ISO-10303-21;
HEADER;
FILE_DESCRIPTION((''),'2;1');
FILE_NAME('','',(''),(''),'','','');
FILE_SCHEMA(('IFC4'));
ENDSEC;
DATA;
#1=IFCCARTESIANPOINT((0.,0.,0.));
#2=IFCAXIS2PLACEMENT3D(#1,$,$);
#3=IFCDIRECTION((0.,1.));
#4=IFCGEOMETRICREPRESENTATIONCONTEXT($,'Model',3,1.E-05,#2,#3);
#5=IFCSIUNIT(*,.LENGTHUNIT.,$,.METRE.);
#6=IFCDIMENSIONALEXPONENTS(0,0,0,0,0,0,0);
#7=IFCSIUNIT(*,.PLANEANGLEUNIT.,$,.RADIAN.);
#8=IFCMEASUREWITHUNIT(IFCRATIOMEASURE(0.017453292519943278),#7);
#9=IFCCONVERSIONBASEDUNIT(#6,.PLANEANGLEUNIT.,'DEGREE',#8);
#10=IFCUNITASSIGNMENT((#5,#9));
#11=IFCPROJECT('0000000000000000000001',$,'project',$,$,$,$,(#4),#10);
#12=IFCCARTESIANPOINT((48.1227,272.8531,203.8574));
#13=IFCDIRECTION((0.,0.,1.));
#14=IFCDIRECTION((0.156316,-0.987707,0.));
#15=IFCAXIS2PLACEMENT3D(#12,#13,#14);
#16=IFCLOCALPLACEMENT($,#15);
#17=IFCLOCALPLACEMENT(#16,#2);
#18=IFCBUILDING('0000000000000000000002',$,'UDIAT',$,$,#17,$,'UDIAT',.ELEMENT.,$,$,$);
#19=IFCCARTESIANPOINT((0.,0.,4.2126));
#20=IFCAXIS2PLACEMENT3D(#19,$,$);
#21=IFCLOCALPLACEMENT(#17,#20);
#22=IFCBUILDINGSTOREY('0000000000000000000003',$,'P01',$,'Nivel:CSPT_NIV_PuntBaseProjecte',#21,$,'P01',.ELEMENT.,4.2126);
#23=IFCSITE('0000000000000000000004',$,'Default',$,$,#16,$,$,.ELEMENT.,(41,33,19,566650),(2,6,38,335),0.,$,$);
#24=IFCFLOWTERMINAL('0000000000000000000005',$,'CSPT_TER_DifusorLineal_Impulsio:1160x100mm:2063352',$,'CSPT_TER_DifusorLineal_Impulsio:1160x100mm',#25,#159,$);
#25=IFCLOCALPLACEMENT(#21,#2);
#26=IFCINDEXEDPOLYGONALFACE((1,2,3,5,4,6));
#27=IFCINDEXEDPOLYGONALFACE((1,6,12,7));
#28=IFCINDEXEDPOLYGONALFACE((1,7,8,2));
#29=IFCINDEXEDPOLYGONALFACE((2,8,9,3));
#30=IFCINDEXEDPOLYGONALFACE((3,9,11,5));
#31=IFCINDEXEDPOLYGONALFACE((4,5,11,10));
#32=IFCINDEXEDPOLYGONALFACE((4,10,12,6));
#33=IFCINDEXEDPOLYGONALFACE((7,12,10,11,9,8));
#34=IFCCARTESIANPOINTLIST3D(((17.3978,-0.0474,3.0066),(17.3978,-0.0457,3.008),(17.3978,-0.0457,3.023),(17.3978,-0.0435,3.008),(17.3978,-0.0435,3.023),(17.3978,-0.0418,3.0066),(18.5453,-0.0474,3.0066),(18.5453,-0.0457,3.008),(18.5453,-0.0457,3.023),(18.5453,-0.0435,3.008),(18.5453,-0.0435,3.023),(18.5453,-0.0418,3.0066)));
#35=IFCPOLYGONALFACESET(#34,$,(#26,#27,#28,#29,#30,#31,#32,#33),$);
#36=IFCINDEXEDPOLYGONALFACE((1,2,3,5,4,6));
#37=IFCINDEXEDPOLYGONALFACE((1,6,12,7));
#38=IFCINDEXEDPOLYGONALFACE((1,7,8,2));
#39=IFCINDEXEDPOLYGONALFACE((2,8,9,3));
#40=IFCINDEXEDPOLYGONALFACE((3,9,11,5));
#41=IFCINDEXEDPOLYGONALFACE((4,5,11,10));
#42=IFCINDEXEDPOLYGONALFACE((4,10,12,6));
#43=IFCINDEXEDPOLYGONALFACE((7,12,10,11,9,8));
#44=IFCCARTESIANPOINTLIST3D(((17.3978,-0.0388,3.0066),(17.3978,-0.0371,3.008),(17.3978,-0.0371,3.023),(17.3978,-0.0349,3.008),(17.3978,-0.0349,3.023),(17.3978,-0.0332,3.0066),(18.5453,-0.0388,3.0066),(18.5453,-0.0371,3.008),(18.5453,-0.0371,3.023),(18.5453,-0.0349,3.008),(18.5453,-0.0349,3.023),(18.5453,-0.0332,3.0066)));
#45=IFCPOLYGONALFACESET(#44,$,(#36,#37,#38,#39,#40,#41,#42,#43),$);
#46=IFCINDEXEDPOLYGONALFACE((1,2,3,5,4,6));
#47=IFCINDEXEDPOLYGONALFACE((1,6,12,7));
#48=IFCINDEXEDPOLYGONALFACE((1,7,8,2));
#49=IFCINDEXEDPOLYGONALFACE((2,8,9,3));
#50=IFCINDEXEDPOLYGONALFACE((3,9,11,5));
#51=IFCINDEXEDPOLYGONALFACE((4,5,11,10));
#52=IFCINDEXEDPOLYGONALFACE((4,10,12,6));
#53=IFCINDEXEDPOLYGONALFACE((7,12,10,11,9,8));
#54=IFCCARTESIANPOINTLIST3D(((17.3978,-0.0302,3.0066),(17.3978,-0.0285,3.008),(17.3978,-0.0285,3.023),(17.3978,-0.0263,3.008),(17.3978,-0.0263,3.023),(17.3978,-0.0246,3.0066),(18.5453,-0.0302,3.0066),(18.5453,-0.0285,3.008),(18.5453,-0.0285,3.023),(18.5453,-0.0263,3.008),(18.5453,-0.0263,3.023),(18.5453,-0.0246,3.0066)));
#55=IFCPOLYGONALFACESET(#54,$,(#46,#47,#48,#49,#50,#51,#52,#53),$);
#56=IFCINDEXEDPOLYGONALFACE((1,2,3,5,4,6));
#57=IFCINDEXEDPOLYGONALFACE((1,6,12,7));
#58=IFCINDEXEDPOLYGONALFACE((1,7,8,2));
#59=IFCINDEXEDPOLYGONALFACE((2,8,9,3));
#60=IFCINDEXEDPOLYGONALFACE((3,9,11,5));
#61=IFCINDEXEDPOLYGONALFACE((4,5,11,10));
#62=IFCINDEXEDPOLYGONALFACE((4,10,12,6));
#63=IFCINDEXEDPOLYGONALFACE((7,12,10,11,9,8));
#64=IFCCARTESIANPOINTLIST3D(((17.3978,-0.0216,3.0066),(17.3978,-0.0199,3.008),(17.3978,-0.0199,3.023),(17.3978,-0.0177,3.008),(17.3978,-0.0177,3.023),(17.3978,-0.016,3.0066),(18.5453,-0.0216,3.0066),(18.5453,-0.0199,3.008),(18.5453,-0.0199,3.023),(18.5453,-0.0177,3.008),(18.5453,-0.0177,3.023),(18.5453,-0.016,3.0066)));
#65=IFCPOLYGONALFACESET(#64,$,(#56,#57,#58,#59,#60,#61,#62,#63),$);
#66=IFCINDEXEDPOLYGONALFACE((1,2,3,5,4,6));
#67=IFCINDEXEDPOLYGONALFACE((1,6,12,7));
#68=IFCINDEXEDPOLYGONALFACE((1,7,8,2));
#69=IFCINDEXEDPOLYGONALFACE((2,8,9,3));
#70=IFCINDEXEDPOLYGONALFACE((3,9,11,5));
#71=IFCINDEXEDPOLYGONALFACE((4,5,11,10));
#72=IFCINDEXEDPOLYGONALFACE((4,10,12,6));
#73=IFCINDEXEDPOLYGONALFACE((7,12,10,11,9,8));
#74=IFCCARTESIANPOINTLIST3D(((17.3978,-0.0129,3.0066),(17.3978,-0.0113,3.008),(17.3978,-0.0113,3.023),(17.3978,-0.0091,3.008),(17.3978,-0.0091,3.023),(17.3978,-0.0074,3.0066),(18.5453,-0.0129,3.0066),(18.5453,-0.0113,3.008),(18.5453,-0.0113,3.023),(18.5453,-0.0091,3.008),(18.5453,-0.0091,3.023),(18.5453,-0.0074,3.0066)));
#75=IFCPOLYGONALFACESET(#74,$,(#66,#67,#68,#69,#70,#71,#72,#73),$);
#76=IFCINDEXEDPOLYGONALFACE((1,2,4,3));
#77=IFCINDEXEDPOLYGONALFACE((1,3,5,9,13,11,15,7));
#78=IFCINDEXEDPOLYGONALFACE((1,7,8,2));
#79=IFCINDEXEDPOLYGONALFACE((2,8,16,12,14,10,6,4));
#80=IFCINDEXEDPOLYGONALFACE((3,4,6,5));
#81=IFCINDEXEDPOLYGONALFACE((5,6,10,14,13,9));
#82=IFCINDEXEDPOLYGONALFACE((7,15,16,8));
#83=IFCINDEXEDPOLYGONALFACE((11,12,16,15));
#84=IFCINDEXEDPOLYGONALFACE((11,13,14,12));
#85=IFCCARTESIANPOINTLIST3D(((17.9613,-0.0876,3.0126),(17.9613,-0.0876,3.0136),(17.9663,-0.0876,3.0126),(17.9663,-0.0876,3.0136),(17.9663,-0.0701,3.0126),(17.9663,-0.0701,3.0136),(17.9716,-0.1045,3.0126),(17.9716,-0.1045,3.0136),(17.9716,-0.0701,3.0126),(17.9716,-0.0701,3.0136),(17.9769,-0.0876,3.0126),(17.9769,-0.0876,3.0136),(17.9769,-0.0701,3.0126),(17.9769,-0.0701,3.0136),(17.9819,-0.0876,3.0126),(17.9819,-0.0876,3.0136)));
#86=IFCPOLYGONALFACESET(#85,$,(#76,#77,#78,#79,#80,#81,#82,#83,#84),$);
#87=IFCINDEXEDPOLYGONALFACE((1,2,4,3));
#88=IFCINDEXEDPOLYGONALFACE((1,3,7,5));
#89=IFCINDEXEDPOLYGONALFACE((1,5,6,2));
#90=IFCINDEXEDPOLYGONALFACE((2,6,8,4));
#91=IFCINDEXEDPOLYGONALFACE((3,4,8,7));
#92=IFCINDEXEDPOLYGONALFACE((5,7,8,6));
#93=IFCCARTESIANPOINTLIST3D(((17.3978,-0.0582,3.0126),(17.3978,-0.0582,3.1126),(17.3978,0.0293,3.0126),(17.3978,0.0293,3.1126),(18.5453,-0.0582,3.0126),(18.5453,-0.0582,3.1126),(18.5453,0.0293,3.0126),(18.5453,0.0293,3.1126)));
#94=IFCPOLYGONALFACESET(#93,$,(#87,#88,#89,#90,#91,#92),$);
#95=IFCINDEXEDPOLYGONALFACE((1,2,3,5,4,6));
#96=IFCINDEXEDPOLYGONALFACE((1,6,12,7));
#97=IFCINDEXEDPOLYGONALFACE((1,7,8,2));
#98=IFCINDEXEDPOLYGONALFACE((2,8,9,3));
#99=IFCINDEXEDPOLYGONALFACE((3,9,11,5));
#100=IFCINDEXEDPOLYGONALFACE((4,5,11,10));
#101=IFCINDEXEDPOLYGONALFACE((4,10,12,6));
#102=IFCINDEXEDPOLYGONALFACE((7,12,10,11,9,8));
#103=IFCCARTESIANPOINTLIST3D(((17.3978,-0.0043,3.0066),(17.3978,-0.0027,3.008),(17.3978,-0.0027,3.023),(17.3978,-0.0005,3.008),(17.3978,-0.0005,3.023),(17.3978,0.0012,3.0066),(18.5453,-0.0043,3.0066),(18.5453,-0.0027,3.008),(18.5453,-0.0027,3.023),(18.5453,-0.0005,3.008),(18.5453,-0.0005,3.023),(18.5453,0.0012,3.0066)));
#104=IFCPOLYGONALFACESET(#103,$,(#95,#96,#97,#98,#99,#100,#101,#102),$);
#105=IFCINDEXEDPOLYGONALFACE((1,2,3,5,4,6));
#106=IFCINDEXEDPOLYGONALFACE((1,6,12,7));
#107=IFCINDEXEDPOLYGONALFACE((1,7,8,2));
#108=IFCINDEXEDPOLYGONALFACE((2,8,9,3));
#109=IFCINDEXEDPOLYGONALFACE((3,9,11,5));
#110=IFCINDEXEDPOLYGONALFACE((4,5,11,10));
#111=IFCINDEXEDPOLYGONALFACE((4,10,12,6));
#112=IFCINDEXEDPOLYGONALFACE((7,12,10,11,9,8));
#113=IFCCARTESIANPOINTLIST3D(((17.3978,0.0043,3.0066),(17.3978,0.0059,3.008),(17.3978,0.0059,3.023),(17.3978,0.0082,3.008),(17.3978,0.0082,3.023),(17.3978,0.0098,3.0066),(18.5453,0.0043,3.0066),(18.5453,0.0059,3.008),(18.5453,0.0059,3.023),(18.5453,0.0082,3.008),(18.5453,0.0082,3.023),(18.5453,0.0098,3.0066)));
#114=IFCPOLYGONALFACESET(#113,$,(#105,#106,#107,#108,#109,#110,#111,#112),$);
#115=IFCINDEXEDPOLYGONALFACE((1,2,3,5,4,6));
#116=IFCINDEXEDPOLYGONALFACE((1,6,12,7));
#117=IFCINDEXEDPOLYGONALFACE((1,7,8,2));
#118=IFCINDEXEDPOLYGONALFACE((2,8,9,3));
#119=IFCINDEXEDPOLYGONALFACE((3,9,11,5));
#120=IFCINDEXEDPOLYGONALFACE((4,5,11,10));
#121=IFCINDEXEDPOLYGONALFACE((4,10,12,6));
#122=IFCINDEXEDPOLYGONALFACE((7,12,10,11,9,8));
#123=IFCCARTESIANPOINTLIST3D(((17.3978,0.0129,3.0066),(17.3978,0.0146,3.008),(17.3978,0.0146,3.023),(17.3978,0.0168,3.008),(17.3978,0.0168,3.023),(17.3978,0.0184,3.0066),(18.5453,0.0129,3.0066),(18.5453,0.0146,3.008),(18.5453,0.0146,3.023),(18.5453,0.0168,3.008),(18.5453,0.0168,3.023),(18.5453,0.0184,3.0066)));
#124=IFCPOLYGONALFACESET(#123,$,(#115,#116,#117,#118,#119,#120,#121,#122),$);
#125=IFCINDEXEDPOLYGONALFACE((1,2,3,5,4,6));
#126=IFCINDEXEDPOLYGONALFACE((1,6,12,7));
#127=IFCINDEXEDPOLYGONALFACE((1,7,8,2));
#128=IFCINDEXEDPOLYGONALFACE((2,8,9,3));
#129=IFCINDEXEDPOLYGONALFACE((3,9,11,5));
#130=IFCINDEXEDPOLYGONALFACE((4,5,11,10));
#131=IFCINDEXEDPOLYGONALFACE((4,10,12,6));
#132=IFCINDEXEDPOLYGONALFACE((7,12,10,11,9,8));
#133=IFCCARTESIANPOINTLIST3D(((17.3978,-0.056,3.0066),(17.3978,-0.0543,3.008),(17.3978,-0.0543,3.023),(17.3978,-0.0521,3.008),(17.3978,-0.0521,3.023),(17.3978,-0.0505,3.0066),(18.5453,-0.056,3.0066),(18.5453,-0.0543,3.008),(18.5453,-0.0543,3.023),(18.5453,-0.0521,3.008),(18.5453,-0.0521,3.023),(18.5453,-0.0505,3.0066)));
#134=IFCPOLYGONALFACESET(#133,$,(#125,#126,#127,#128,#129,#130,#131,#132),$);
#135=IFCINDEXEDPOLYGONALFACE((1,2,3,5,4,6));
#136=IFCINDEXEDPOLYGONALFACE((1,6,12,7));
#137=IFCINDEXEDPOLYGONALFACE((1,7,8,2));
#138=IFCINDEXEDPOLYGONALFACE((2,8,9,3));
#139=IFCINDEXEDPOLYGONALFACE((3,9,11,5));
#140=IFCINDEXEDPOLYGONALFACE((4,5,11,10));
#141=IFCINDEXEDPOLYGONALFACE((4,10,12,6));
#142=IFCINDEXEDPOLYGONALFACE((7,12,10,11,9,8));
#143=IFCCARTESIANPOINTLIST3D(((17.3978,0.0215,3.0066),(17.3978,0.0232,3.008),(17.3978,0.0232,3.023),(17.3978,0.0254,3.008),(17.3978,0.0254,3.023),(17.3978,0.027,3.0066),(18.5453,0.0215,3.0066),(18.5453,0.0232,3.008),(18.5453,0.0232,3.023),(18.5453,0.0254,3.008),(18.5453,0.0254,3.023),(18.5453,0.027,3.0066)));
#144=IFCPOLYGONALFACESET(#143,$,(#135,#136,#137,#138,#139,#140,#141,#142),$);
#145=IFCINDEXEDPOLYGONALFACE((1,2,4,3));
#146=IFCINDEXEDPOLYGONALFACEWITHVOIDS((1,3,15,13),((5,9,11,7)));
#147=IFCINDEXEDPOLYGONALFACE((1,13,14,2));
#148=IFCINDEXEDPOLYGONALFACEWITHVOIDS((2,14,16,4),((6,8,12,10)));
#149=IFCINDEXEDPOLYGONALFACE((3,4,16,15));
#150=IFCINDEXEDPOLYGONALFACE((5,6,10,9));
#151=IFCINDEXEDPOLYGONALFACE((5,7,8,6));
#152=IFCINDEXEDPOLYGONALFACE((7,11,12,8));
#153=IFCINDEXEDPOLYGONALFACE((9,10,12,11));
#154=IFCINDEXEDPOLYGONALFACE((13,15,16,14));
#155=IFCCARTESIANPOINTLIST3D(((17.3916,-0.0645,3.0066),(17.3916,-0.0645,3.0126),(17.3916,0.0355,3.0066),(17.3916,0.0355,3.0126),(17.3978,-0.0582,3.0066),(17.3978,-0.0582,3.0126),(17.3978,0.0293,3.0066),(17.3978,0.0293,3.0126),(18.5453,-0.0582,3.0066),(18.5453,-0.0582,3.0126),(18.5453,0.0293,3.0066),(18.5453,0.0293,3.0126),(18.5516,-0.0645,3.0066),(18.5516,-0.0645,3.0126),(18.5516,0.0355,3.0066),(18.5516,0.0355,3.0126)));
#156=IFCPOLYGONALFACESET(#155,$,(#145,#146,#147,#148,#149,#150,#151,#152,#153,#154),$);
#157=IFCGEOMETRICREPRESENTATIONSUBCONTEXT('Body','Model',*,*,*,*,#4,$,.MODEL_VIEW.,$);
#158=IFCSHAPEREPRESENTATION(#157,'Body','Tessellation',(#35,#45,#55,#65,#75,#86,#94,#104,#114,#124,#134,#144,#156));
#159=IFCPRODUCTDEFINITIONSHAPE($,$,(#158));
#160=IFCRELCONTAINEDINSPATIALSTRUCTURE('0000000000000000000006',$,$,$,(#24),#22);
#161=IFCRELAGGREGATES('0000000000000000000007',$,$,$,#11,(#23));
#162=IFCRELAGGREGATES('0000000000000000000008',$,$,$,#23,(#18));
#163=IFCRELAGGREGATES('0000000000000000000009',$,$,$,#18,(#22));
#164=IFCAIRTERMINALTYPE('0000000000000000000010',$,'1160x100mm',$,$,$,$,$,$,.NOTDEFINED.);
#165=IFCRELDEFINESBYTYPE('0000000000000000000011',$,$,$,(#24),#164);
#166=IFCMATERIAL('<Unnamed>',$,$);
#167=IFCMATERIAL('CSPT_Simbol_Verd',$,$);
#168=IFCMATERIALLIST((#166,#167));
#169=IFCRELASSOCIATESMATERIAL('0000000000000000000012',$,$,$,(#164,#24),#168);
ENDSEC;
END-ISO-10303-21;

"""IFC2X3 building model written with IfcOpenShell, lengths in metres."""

from ifc_helpers import new_model, entity, si_unit, converted_unit, direction, frame, origin, origin_2d_with_axis, place, context, subcontext, project, spatial, polyline, rectangle, outline, extrude, source, transform, mapped, material, material_list, type_object, type_shapes, element, save


model = new_model("IFC2X3")

# Units and contexts
model_context = context("Model", 3, precision=1e-05, world=origin(), true_north=direction((0.0, 1.0)))
body_context = subcontext(model_context, "Body", "Model", "MODEL_VIEW")
ifc_project = project(units=[si_unit("LENGTHUNIT", "METRE"), converted_unit("PLANEANGLEUNIT", "DEGREE", entity("IfcRatioMeasure", 0.017453292519943278), si_unit("PLANEANGLEUNIT", "RADIAN"), dimensions=[0, 0, 0, 0, 0, 0, 0])], contexts=[model_context])

# Site, building, storey
site_placement = place(None, frame((48.1227, 272.8531, 203.8574), z_axis=(0.0, 0.0, 1.0), x_axis=(0.156316, -0.987707, 0.0)))
site = spatial("IfcSite", under=ifc_project, at=site_placement, Name="Default", CompositionType="ELEMENT", RefLatitude=(41, 33, 19, 566650), RefLongitude=(2, 6, 38, 335), RefElevation=0.0)
building_placement = place(site_placement, origin())
building = spatial("IfcBuilding", under=site, at=building_placement, Name="UDIAT", LongName="UDIAT", CompositionType="ELEMENT")
storey_placement = place(building_placement, frame((0.0, 0.0, 4.2126)))
storey = spatial("IfcBuildingStorey", under=building, at=storey_placement, Name="P01", ObjectType="Nivel:CSPT_NIV_PuntBaseProjecte", LongName="P01", CompositionType="ELEMENT", Elevation=4.2126)

# Shared definitions
ifc_material_1 = material(Name="<Unnamed>")

# Flow terminal
ifc_material_2 = material(Name="CSPT_Simbol_Verd")
ifc_material_list = material_list([ifc_material_1, ifc_material_2])
air_terminal_type = type_object("IfcAirTerminalType", Name="1160x100mm", PredefinedType="NOTDEFINED", material=ifc_material_list)
shared_shape_1 = source(origin(), body_context, "Body", "SweptSolid", [
    extrude(outline(polyline([(0.0037, 0.0028), (0.0059, 0.0028), (0.0016, 0.0063), (0.002, 0.0042), (-0.0074, -0.0074), (-0.0057, -0.0088), (0.0037, 0.0028)])), frame((-0.5737, 0.0301, -0.0001), z_axis=(1.0, 0.0, 0.0), x_axis=(0.0, -0.776119, -0.630587)), (0.0, 0.0, 1.0), 1.1475),
    extrude(outline(polyline([(0.0037, 0.0028), (0.0059, 0.0028), (0.0016, 0.0063), (0.002, 0.0042), (-0.0074, -0.0074), (-0.0057, -0.0088), (0.0037, 0.0028)])), frame((-0.5737, 0.0215, -0.0001), z_axis=(1.0, 0.0, 0.0), x_axis=(0.0, -0.776119, -0.630587)), (0.0, 0.0, 1.0), 1.1475),
    extrude(outline(polyline([(0.0037, 0.0028), (0.0059, 0.0028), (0.0016, 0.0063), (0.002, 0.0042), (-0.0074, -0.0074), (-0.0057, -0.0088), (0.0037, 0.0028)])), frame((-0.5737, 0.0129, -0.0001), z_axis=(1.0, 0.0, 0.0), x_axis=(0.0, -0.776119, -0.630587)), (0.0, 0.0, 1.0), 1.1475),
    extrude(outline(polyline([(0.0037, 0.0028), (0.0059, 0.0028), (0.0016, 0.0063), (0.002, 0.0042), (-0.0074, -0.0074), (-0.0057, -0.0088), (0.0037, 0.0028)])), frame((-0.5737, 0.0043, -0.0001), z_axis=(1.0, 0.0, 0.0), x_axis=(0.0, -0.776119, -0.630587)), (0.0, 0.0, 1.0), 1.1475),
    extrude(outline(polyline([(0.0037, 0.0028), (0.0059, 0.0028), (0.0016, 0.0063), (0.002, 0.0042), (-0.0074, -0.0074), (-0.0057, -0.0088), (0.0037, 0.0028)])), frame((-0.5737, -0.0043, -0.0001), z_axis=(1.0, 0.0, 0.0), x_axis=(0.0, -0.776119, -0.630587)), (0.0, 0.0, 1.0), 1.1475),
    extrude(outline(polyline([(0.0, -0.013), (0.0053, -0.013), (0.0053, 0.0045), (0.0103, 0.0045), (0.0, 0.0213), (-0.0103, 0.0045), (-0.0053, 0.0045), (-0.0053, -0.013), (0.0, -0.013)])), frame((0.0, 0.0687, 0.0)), (0.0, 0.0, 1.0), 0.001),
    extrude(rectangle(XDim=1.1475, YDim=0.0875, at=origin_2d_with_axis()), frame((0.0, 0.0, 0.0), z_axis=(0.0, 0.0, 1.0), x_axis=(-1.0, 0.0, 0.0)), (0.0, 0.0, 1.0), 0.1),
    extrude(outline(polyline([(0.0037, 0.0028), (0.0059, 0.0028), (0.0016, 0.0063), (0.002, 0.0042), (-0.0074, -0.0074), (-0.0057, -0.0088), (0.0037, 0.0028)])), frame((-0.5737, -0.0129, -0.0001), z_axis=(1.0, 0.0, 0.0), x_axis=(0.0, -0.776119, -0.630587)), (0.0, 0.0, 1.0), 1.1475),
    extrude(outline(polyline([(0.0037, 0.0028), (0.0059, 0.0028), (0.0016, 0.0063), (0.002, 0.0042), (-0.0074, -0.0074), (-0.0057, -0.0088), (0.0037, 0.0028)])), frame((-0.5737, -0.0215, -0.0001), z_axis=(1.0, 0.0, 0.0), x_axis=(0.0, -0.776119, -0.630587)), (0.0, 0.0, 1.0), 1.1475),
    extrude(outline(polyline([(0.0037, 0.0028), (0.0059, 0.0028), (0.0016, 0.0063), (0.002, 0.0042), (-0.0074, -0.0074), (-0.0057, -0.0088), (0.0037, 0.0028)])), frame((-0.5737, -0.0301, -0.0001), z_axis=(1.0, 0.0, 0.0), x_axis=(0.0, -0.776119, -0.630587)), (0.0, 0.0, 1.0), 1.1475),
    extrude(outline(polyline([(0.0037, 0.0028), (0.0059, 0.0028), (0.0016, 0.0063), (0.002, 0.0042), (-0.0074, -0.0074), (-0.0057, -0.0088), (0.0037, 0.0028)])), frame((-0.5737, 0.0388, -0.0001), z_axis=(1.0, 0.0, 0.0), x_axis=(0.0, -0.776119, -0.630587)), (0.0, 0.0, 1.0), 1.1475),
    extrude(outline(polyline([(0.0037, 0.0028), (0.0059, 0.0028), (0.0016, 0.0063), (0.002, 0.0042), (-0.0074, -0.0074), (-0.0057, -0.0088), (0.0037, 0.0028)])), frame((-0.5737, -0.0387, -0.0001), z_axis=(1.0, 0.0, 0.0), x_axis=(0.0, -0.776119, -0.630587)), (0.0, 0.0, 1.0), 1.1475),
    extrude(outline(polyline([(-0.58, -0.05), (0.58, -0.05), (0.58, 0.05), (-0.58, 0.05), (-0.58, -0.05)]), holes=[polyline([(-0.5738, -0.0438), (-0.5738, 0.0437), (0.5737, 0.0437), (0.5737, -0.0438), (-0.5738, -0.0438)])]), frame((0.0, 0.0, -0.006), z_axis=(0.0, 0.0, 1.0), x_axis=(-1.0, 0.0, 0.0)), (0.0, 0.0, 1.0), 0.006),
])
type_shapes(air_terminal_type, [shared_shape_1])
for number, where, z_axis, x_axis, name in (
    (1, (17.9716, -0.0145, 3.0126), (0.0, 0.0, 1.0), (-1.0, 0.0, 0.0), "CSPT_TER_DifusorLineal_Impulsio:1160x100mm:2063352"),
):
    element("IfcFlowTerminal", number, at=place(storey_placement, frame(where, z_axis=z_axis, x_axis=x_axis)), inside=storey, type_object=air_terminal_type, material=ifc_material_list, Name=name, ObjectType="CSPT_TER_DifusorLineal_Impulsio:1160x100mm", context=body_context, shape_type="MappedRepresentation", body=[
        mapped(shared_shape_1, transform((0.0, 0.0, 0.0), scale=1.0)),
    ])

save(model, "model.ifc")
